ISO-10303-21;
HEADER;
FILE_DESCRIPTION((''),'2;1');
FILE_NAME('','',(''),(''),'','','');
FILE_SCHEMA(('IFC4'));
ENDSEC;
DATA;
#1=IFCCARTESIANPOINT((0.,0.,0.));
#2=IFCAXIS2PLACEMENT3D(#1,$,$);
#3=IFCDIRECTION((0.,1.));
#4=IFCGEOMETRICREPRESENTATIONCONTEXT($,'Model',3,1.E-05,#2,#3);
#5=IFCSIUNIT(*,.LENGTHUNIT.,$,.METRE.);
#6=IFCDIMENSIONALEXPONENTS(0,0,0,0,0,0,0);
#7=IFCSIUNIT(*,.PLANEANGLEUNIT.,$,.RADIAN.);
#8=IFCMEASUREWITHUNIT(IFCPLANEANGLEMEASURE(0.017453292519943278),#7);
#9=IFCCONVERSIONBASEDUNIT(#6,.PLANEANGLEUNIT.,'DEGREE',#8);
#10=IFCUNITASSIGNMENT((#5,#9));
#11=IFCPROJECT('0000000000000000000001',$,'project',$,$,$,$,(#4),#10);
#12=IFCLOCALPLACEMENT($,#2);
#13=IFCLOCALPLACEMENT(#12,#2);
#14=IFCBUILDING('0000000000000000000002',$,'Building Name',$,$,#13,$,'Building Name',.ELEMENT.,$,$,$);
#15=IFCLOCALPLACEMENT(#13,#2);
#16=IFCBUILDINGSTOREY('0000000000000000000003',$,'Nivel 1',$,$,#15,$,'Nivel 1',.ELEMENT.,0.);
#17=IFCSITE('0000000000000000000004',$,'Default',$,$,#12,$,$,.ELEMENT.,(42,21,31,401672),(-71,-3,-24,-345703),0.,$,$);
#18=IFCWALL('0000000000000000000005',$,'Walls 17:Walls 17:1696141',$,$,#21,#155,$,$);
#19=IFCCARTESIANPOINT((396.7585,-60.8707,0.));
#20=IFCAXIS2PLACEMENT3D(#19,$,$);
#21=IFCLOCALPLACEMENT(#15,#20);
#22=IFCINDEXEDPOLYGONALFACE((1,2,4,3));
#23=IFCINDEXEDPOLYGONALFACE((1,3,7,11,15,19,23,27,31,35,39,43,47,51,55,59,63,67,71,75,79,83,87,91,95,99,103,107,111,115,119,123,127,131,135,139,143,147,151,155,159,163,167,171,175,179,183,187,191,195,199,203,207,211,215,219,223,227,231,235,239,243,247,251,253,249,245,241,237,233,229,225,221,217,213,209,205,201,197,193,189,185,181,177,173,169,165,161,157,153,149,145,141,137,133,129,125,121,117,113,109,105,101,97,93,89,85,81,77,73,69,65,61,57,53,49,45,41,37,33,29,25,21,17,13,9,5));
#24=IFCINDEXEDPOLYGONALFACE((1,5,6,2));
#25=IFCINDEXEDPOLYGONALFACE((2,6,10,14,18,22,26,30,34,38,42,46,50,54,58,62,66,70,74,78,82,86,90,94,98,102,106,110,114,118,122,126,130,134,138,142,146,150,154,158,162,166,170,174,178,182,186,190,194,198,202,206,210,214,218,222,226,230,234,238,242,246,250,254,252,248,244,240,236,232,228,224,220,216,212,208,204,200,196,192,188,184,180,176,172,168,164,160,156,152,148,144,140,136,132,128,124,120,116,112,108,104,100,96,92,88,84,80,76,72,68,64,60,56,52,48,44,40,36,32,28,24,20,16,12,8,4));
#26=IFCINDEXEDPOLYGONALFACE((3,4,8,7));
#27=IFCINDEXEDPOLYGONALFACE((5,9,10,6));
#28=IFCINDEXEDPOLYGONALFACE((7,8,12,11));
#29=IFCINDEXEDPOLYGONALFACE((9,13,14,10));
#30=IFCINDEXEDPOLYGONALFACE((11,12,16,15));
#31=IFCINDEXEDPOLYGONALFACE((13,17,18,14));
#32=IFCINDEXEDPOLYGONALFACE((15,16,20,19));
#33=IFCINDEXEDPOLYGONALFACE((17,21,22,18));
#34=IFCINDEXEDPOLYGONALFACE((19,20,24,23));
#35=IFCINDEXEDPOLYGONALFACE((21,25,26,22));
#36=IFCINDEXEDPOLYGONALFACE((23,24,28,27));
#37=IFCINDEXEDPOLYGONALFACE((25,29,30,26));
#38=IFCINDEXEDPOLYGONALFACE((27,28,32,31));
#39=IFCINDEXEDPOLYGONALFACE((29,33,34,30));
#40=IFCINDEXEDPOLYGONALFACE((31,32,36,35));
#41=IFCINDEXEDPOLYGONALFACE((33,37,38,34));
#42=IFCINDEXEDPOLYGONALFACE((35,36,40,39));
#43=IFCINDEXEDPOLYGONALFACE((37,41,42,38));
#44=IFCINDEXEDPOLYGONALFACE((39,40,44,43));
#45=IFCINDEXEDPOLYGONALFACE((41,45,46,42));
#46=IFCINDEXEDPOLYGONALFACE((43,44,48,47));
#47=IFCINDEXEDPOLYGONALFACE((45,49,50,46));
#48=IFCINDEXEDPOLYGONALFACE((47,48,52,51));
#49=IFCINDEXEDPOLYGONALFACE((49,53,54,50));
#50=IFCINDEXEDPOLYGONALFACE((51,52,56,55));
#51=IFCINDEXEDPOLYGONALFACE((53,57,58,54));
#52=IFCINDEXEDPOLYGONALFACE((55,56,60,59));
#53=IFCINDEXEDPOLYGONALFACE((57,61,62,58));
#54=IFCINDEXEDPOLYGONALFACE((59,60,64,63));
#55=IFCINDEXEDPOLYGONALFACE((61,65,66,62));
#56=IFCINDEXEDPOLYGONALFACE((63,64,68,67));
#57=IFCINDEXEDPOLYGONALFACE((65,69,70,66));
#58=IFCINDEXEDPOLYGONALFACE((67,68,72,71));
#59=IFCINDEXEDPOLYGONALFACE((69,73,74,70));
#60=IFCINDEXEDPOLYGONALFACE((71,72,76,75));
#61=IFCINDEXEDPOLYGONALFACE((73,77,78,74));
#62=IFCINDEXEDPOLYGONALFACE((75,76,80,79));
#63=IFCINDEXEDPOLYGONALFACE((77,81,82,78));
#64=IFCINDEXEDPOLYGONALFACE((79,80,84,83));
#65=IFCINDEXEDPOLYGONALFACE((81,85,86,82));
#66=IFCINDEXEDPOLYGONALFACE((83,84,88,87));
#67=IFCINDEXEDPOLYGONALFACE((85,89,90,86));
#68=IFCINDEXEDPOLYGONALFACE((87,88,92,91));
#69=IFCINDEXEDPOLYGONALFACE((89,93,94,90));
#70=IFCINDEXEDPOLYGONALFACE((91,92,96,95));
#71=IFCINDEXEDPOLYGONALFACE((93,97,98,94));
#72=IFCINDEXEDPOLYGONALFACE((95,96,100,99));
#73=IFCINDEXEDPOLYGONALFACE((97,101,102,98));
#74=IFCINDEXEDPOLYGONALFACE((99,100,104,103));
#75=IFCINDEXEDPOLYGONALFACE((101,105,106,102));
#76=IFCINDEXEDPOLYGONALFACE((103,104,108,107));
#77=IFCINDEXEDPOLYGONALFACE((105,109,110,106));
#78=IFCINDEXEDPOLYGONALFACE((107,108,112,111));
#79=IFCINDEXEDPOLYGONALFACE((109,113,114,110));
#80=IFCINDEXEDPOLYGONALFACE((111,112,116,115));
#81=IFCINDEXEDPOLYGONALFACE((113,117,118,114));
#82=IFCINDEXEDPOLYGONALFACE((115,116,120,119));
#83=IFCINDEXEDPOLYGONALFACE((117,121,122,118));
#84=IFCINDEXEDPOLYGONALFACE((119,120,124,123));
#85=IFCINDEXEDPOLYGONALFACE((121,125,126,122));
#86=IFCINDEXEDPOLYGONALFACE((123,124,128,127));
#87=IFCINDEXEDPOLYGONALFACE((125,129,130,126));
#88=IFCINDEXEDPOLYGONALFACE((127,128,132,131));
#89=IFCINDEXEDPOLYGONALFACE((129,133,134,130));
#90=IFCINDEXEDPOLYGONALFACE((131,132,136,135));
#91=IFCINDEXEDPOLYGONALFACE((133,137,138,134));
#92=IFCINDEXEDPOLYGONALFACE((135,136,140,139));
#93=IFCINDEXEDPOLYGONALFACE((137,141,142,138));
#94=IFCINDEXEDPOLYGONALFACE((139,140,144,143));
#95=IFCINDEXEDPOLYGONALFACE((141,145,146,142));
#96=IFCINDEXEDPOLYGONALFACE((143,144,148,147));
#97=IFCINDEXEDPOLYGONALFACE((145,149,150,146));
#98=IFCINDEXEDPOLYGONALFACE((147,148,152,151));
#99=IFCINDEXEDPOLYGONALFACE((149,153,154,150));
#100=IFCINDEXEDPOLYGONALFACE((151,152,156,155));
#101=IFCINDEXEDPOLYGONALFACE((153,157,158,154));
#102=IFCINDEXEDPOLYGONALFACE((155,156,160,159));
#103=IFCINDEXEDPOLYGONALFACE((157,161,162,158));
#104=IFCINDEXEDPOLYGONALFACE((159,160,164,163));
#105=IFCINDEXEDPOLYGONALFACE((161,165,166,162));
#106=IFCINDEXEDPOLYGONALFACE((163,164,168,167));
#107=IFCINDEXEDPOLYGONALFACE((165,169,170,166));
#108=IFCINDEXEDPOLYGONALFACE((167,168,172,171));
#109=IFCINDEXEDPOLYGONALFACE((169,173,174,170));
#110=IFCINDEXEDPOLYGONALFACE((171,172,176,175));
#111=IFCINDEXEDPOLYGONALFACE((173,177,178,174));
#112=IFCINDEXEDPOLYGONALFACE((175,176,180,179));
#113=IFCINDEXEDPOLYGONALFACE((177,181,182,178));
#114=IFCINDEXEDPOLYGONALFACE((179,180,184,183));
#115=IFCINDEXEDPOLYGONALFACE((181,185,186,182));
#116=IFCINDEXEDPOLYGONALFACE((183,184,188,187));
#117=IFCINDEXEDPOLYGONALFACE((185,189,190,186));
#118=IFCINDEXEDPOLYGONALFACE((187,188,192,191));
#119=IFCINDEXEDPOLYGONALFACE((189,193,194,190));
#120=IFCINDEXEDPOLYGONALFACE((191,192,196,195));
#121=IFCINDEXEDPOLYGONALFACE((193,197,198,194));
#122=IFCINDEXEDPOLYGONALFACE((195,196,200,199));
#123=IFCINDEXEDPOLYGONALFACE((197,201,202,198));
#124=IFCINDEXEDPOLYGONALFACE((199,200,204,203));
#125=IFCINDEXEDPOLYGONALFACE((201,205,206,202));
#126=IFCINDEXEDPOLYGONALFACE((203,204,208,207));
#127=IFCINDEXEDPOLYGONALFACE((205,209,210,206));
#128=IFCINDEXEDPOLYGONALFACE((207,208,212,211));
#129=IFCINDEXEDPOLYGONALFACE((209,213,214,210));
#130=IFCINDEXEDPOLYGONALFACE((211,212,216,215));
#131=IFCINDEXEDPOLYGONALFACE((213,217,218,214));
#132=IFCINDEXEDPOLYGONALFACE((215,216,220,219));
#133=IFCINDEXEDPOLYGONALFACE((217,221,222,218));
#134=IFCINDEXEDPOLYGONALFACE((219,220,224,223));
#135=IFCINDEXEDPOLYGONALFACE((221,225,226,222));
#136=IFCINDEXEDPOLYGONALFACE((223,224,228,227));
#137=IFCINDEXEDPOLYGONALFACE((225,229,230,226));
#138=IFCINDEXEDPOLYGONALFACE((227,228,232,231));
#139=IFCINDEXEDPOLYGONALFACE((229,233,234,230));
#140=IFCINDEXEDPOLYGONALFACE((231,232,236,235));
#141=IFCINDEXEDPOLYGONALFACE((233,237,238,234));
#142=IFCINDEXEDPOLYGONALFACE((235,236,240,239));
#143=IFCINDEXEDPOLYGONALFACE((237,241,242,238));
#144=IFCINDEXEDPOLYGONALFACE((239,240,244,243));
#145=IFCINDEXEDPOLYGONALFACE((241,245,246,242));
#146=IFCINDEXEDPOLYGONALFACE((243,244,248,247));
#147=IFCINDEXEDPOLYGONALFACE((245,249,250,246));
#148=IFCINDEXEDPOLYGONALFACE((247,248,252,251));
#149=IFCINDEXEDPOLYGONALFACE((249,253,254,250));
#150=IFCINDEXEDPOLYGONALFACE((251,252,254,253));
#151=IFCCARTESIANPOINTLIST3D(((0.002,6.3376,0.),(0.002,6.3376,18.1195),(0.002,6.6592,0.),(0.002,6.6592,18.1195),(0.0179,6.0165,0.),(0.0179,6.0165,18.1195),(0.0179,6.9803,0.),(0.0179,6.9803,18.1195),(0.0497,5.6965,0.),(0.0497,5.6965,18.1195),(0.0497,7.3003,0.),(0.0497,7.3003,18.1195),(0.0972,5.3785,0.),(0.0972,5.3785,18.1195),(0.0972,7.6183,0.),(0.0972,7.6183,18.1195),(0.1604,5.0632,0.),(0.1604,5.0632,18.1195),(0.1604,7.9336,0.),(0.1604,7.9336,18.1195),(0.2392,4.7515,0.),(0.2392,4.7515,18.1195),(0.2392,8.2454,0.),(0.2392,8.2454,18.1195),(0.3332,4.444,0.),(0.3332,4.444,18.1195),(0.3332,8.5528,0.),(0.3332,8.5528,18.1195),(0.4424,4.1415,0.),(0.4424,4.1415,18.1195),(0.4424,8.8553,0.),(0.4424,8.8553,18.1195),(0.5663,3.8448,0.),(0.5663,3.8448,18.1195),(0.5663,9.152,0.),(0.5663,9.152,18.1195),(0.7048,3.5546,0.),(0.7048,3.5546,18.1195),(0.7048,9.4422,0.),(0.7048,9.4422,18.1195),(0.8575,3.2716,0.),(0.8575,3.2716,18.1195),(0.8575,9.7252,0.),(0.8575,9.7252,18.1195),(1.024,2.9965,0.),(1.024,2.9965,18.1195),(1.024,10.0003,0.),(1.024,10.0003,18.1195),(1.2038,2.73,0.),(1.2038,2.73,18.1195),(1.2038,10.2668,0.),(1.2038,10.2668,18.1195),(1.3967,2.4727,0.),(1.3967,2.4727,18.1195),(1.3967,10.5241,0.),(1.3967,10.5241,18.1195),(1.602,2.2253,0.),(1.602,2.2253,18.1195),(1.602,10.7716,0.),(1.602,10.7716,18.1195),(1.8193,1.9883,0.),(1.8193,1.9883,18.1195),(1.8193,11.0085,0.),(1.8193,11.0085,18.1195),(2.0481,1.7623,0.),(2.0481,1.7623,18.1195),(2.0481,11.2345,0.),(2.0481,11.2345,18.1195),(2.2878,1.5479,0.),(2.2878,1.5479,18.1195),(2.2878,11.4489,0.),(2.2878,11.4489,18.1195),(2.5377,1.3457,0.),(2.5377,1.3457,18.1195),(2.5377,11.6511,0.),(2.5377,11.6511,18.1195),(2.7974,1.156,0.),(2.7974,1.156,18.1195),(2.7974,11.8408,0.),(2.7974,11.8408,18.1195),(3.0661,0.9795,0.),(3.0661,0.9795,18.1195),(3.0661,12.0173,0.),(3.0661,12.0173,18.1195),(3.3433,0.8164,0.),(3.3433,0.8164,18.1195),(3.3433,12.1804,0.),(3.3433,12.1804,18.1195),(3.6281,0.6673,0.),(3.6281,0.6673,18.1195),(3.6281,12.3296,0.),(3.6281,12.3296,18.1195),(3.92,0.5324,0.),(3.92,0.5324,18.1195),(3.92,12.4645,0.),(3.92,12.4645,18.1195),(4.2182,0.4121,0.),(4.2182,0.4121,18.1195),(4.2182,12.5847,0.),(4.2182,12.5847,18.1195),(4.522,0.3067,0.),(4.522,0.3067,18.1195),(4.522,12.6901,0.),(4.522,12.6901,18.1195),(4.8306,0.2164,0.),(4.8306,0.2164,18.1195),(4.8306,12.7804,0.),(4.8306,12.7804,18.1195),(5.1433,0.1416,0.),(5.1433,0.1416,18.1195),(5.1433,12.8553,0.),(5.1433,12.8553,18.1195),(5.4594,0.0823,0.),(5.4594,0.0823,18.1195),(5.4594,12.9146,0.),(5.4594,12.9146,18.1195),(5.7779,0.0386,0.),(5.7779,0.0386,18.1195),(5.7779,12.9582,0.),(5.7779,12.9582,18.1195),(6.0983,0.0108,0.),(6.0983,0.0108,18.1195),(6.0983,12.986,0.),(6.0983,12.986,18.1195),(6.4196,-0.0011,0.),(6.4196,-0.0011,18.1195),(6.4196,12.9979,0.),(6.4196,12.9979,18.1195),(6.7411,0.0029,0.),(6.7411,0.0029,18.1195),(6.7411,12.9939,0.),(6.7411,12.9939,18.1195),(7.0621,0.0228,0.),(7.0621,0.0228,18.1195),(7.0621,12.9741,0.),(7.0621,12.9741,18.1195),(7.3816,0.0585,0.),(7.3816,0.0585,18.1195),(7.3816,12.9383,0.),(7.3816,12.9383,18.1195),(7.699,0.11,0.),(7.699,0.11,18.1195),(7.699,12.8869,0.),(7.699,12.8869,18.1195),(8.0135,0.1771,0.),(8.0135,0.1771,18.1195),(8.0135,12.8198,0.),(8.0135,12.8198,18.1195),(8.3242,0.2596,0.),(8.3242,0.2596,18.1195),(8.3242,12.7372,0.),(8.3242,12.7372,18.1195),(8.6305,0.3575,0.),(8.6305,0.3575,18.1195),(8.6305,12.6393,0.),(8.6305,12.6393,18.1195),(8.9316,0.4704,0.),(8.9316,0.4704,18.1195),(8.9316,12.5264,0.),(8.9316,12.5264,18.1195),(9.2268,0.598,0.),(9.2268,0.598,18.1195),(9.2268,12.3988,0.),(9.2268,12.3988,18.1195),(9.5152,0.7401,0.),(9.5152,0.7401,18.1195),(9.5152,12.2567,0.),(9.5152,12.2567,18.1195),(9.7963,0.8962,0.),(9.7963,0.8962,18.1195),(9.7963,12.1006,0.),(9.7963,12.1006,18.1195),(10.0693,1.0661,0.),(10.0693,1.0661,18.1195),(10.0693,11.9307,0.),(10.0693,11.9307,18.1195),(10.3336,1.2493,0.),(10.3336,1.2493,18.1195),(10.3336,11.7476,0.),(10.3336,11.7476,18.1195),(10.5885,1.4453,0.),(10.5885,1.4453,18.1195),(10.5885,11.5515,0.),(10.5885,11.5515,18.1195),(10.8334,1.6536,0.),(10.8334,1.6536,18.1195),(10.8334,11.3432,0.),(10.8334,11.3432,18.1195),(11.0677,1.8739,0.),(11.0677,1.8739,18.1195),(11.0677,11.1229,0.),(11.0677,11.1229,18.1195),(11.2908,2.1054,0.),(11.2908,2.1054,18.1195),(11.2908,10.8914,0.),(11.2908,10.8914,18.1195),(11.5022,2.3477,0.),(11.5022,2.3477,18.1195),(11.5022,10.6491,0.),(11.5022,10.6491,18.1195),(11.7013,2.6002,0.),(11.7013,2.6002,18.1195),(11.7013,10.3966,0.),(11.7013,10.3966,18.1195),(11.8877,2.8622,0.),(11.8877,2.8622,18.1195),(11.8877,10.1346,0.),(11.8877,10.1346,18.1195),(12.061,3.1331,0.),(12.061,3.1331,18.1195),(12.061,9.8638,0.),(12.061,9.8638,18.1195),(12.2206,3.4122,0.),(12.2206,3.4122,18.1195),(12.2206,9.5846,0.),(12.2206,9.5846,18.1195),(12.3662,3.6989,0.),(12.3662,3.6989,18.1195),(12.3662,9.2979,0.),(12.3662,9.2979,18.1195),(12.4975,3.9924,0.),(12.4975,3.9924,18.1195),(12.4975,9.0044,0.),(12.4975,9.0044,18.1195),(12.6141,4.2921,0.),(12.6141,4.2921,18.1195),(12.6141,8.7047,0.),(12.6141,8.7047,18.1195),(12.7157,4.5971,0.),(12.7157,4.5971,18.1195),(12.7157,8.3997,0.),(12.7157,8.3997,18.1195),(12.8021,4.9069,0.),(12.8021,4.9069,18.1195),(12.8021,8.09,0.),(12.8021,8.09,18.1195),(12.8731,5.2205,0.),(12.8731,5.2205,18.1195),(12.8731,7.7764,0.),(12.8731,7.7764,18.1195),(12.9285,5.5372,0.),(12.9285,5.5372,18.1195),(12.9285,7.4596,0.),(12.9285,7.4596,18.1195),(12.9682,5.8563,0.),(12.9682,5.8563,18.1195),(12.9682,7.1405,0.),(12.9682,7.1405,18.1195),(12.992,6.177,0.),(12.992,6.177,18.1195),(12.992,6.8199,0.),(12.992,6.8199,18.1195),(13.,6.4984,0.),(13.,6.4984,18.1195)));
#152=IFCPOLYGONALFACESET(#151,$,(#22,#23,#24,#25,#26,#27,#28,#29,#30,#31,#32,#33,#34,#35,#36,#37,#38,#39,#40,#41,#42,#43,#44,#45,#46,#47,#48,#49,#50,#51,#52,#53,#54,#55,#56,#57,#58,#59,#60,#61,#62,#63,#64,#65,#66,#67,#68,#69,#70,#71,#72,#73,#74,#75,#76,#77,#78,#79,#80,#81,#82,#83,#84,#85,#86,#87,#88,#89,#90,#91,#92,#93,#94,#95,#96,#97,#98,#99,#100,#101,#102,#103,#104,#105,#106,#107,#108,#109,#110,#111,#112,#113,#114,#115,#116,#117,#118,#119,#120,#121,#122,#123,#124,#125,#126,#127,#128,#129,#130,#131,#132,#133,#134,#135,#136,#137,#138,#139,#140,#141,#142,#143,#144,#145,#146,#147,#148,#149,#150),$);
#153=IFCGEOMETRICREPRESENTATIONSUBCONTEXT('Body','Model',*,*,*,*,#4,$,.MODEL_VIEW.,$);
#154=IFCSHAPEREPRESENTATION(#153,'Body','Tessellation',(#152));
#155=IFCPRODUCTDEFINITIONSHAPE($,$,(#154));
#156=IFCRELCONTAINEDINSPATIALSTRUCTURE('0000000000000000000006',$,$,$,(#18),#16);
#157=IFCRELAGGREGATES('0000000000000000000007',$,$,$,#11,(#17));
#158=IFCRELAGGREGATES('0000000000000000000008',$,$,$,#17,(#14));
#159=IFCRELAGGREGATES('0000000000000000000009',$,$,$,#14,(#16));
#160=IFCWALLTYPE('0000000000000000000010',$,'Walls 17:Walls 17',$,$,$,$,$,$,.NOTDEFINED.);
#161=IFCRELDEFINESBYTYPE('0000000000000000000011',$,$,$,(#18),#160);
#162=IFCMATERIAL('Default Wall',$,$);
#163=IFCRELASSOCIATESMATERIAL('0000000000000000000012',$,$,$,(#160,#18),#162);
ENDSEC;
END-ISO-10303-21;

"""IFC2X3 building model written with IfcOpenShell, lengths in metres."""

from ifc_helpers import new_model, entity, si_unit, converted_unit, direction, frame, frame_2d, origin, place, context, subcontext, project, spatial, circle, extrude, material, type_object, element, save


model = new_model("IFC2X3")

# Units and contexts
model_context = context("Model", 3, precision=1e-05, world=origin(), true_north=direction((0.0, 1.0)))
body_context = subcontext(model_context, "Body", "Model", "MODEL_VIEW")
ifc_project = project(units=[si_unit("LENGTHUNIT", "METRE"), converted_unit("PLANEANGLEUNIT", "DEGREE", entity("IfcPlaneAngleMeasure", 0.017453292519943278), si_unit("PLANEANGLEUNIT", "RADIAN"), dimensions=[0, 0, 0, 0, 0, 0, 0])], contexts=[model_context])

# Site, building, storey
site_placement = place(None, origin())
site = spatial("IfcSite", under=ifc_project, at=site_placement, Name="Default", CompositionType="ELEMENT", RefLatitude=(42, 21, 31, 401672), RefLongitude=(-71, -3, -24, -345703), RefElevation=0.0)
building_placement = place(site_placement, origin())
building = spatial("IfcBuilding", under=site, at=building_placement, Name="Building Name", LongName="Building Name", CompositionType="ELEMENT")
storey_placement = place(building_placement, origin())
storey = spatial("IfcBuildingStorey", under=building, at=storey_placement, Name="Nivel 1", LongName="Nivel 1", CompositionType="ELEMENT", Elevation=0.0)

# Wall
ifc_material_1 = material(Name="Default Wall")
wall_type_1 = type_object("IfcWallType", Name="Walls 17:Walls 17", PredefinedType="NOTDEFINED", material=ifc_material_1)
wall_1_placement = place(storey_placement, frame((396.7585, -60.8707, 0.0)))
element("IfcWall", 1, at=wall_1_placement, inside=storey, type_object=wall_type_1, material=ifc_material_1, Name="Walls 17:Walls 17:1696141", context=body_context, shape_type="SweptSolid", body=[
    extrude(circle(Radius=6.5, at=frame_2d((0.0, 0.0), x_axis=(1.0, 0.0))), frame((6.5, 6.4984, 0.0)), (0.0, 0.0, 1.0), 18.1195),
])

save(model, "model.ifc")
